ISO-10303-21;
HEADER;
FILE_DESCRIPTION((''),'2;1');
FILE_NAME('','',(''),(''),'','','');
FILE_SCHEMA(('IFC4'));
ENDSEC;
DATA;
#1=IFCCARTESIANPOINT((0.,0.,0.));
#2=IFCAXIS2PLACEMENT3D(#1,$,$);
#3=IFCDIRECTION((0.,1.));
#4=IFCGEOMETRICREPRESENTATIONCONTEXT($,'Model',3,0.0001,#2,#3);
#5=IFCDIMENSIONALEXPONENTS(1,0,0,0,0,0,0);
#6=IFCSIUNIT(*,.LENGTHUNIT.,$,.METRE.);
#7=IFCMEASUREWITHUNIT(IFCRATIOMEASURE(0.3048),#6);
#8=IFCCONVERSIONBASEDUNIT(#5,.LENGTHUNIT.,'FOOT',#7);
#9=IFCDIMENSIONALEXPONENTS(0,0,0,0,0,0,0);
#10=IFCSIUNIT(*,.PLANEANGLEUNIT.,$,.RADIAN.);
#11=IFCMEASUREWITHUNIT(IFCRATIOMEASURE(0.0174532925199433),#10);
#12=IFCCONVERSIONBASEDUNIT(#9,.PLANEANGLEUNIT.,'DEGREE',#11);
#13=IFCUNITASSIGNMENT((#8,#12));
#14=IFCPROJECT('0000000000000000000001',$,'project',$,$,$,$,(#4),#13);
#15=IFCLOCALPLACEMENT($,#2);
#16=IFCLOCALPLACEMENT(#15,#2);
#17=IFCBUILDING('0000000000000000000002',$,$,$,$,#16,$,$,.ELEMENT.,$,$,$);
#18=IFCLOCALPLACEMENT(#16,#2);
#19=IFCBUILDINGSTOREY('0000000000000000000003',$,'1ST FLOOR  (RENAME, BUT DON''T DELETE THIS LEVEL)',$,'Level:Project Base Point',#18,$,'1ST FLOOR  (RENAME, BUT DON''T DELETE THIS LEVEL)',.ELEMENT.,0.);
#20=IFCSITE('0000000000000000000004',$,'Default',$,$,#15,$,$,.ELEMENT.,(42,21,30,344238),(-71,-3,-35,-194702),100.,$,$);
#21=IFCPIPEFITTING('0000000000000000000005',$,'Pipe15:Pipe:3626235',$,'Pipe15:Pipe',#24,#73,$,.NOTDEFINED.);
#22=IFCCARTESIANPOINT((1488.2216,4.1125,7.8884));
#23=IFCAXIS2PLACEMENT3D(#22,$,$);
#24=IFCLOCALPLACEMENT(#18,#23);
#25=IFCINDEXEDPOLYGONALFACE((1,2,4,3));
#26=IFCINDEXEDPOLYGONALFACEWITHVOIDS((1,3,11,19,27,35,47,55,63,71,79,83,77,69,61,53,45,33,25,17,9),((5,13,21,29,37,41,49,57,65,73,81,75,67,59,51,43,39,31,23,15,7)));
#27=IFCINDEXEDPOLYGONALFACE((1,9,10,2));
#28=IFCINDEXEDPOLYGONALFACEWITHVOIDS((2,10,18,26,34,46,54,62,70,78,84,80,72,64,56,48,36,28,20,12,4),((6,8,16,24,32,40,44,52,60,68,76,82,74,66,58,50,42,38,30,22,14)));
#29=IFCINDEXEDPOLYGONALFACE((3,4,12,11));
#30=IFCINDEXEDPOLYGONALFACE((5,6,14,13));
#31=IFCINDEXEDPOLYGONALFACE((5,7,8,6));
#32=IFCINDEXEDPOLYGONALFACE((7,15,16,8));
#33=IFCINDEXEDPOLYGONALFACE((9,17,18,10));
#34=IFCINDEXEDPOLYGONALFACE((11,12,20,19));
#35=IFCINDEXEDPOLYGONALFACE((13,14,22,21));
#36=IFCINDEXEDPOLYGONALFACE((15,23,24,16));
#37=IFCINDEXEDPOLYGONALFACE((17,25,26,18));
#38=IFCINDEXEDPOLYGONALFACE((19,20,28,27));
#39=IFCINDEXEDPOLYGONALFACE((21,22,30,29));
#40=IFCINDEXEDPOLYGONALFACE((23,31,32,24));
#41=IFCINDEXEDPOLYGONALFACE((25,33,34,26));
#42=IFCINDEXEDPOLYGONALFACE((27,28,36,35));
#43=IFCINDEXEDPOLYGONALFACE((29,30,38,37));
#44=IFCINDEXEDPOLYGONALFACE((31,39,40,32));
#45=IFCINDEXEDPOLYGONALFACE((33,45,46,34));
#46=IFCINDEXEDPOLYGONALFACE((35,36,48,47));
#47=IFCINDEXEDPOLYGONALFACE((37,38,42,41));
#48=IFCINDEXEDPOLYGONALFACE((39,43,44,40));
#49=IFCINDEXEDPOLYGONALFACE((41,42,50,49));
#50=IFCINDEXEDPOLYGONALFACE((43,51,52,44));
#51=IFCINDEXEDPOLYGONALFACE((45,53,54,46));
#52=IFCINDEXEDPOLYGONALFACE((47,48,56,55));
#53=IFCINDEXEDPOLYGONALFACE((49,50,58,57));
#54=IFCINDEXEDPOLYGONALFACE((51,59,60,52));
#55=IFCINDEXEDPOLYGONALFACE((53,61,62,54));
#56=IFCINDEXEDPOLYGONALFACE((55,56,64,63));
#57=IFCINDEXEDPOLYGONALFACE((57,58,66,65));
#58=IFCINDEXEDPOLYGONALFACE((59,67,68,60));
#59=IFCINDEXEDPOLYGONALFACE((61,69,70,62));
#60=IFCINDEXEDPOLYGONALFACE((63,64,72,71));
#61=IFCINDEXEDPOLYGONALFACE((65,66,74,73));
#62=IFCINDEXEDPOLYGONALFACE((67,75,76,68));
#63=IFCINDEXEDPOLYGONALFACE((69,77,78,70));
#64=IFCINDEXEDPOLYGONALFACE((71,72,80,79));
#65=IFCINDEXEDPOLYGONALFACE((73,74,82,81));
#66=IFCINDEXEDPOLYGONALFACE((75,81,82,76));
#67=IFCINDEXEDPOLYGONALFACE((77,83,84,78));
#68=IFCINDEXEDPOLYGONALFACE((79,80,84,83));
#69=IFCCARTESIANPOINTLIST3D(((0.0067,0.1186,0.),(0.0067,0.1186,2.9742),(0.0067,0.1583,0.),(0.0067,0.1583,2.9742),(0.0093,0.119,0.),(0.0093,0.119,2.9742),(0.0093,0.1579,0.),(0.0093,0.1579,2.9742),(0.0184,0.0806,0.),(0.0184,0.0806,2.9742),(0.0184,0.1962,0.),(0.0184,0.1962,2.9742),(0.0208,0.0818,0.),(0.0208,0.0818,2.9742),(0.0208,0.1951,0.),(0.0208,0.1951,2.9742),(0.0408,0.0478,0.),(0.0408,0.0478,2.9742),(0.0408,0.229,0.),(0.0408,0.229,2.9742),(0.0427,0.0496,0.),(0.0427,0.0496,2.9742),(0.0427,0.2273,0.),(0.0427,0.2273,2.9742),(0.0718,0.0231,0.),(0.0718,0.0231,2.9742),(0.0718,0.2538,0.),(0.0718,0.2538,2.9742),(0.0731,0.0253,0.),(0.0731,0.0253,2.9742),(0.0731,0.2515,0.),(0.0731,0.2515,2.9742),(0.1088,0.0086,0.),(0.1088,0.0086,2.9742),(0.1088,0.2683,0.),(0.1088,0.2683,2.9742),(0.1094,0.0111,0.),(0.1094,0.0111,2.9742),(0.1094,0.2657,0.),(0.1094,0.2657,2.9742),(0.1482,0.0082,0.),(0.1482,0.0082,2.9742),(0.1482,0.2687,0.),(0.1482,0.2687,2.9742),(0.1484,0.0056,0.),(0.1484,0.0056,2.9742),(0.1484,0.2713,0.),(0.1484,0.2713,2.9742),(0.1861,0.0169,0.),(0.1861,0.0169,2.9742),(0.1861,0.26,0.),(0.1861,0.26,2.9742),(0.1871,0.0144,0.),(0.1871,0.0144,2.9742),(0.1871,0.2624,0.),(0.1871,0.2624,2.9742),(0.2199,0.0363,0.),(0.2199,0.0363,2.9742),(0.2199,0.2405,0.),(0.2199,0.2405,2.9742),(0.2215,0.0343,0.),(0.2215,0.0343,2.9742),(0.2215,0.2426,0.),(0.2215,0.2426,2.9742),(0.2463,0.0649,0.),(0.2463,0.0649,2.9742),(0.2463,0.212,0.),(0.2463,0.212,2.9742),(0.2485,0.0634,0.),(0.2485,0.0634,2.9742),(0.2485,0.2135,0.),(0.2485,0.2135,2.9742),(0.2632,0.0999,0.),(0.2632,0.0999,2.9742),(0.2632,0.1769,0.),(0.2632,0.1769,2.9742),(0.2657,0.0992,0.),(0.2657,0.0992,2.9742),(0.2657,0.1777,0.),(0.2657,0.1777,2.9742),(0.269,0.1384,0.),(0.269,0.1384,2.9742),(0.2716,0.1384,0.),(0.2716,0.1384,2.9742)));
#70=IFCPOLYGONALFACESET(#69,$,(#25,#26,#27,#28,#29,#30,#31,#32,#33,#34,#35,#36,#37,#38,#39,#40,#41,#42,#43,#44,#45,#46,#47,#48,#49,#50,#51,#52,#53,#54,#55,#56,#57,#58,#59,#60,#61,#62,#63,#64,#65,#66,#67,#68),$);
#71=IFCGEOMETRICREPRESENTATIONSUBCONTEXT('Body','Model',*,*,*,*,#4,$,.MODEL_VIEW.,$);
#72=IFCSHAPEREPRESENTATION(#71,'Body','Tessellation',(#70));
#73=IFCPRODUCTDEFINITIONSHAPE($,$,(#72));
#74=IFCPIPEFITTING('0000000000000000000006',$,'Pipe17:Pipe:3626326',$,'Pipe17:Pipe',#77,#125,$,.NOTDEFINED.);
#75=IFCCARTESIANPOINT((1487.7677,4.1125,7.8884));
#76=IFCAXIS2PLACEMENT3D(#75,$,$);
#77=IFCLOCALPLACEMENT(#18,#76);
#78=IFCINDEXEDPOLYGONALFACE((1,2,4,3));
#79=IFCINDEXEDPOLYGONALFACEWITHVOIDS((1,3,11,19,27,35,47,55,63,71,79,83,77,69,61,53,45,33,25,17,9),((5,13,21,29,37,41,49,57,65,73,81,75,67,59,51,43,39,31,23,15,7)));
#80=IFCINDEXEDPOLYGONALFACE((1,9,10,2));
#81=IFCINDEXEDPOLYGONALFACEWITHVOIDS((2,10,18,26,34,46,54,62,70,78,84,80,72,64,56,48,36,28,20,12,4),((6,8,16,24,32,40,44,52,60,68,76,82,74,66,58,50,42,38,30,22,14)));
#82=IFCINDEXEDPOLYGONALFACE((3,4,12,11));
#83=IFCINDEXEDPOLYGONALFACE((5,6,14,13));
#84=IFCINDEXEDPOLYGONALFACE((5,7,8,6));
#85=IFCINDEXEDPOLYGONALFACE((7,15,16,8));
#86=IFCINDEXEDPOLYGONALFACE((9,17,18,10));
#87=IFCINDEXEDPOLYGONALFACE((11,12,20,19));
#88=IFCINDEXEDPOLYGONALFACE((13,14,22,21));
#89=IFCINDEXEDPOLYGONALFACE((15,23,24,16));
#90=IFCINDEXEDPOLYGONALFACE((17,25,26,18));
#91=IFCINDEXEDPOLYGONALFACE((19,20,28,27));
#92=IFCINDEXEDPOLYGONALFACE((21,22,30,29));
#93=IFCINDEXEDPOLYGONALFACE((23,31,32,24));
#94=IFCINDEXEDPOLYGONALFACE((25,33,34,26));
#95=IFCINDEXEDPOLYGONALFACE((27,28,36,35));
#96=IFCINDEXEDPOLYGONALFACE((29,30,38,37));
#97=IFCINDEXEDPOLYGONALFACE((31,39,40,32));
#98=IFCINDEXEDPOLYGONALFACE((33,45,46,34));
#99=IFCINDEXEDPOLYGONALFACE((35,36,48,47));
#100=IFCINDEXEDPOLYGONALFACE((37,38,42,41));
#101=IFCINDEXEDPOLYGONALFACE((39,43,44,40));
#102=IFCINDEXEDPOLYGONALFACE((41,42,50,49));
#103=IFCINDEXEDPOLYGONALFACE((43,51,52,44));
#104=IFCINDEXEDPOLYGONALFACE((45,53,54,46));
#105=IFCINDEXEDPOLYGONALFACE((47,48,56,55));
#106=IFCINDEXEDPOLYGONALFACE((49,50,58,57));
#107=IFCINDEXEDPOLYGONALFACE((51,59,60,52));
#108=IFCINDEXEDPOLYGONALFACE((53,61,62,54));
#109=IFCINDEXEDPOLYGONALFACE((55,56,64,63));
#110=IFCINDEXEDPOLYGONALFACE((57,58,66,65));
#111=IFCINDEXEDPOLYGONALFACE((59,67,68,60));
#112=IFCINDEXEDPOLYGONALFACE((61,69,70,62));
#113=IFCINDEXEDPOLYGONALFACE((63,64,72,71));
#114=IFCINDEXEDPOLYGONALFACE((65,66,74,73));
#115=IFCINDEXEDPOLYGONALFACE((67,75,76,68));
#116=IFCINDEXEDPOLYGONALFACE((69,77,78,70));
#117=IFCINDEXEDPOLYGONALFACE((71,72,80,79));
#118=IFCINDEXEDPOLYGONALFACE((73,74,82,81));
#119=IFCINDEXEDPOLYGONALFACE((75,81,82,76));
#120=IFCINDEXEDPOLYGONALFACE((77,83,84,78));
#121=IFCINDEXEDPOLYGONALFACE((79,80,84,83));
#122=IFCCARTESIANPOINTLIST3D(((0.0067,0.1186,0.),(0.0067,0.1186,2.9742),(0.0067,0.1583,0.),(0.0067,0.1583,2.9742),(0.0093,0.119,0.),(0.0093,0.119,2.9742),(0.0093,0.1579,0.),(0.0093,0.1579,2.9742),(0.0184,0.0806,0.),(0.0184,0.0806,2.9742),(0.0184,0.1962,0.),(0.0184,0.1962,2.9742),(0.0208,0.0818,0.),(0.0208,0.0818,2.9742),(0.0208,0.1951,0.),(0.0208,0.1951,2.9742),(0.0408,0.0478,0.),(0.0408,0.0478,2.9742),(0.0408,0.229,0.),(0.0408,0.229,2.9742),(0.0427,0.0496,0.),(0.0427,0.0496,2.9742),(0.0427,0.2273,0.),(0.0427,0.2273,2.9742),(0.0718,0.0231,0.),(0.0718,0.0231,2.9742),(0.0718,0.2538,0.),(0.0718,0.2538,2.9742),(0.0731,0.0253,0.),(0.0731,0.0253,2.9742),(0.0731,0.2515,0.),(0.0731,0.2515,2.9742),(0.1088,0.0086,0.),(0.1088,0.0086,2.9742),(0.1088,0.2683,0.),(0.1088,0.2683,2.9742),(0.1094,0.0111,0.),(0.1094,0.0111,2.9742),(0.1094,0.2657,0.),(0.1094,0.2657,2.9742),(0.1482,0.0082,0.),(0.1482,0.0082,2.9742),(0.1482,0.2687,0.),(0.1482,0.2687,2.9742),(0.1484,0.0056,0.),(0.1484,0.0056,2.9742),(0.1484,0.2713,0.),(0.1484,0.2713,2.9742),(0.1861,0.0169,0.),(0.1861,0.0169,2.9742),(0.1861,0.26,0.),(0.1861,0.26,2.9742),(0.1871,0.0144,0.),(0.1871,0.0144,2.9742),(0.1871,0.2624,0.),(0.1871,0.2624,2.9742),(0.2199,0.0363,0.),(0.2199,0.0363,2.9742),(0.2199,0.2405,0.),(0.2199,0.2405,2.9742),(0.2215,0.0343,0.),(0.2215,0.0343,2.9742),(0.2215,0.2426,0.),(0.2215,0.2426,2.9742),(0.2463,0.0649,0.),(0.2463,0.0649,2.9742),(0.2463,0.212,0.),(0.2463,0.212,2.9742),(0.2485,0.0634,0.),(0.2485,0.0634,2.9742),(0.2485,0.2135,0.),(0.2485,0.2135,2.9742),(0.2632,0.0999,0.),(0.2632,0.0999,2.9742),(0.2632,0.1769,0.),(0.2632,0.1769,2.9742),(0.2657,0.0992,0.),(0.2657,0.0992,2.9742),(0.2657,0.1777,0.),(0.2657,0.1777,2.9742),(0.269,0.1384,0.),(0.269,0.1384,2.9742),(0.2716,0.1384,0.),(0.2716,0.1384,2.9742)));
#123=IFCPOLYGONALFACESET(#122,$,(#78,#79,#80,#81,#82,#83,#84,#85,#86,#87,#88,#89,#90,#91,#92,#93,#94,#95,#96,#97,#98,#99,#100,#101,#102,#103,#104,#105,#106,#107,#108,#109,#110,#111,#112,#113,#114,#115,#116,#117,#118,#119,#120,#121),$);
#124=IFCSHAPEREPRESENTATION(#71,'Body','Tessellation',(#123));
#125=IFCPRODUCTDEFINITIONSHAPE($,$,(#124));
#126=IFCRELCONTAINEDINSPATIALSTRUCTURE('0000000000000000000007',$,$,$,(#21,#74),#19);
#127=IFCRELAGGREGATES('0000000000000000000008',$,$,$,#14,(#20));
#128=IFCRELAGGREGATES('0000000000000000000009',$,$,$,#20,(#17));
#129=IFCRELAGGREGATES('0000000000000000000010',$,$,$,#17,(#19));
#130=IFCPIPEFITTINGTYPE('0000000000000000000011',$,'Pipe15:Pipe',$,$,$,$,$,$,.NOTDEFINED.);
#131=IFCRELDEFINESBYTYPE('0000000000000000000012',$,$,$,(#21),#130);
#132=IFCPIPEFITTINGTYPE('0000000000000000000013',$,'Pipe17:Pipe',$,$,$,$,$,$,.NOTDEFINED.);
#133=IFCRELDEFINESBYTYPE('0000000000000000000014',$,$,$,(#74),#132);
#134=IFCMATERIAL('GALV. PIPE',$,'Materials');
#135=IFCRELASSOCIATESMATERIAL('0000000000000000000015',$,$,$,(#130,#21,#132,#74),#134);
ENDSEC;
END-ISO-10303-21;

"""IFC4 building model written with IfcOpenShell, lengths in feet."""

from ifc_helpers import new_model, entity, si_unit, converted_unit, direction, frame, frame_2d, origin, place, context, subcontext, project, spatial, hollow_circle, extrude, source, transform, mapped, material, type_object, type_shapes, element, save


model = new_model("IFC4")

# Units and contexts
model_context = context("Model", 3, precision=0.0001, world=origin(), true_north=direction((0.0, 1.0)))
body_context = subcontext(model_context, "Body", "Model", "MODEL_VIEW")
ifc_project = project(units=[converted_unit("LENGTHUNIT", "FOOT", entity("IfcRatioMeasure", 0.3048), si_unit("LENGTHUNIT", "METRE"), dimensions=[1, 0, 0, 0, 0, 0, 0]), converted_unit("PLANEANGLEUNIT", "DEGREE", entity("IfcRatioMeasure", 0.0174532925199433), si_unit("PLANEANGLEUNIT", "RADIAN"), dimensions=[0, 0, 0, 0, 0, 0, 0])], contexts=[model_context])

# Site, building, storey
site_placement = place(None, origin())
site = spatial("IfcSite", under=ifc_project, at=site_placement, Name="Default", CompositionType="ELEMENT", RefLatitude=(42, 21, 30, 344238), RefLongitude=(-71, -3, -35, -194702), RefElevation=100.0)
building_placement = place(site_placement, origin())
building = spatial("IfcBuilding", under=site, at=building_placement, CompositionType="ELEMENT")
storey_placement = place(building_placement, origin())
storey = spatial("IfcBuildingStorey", under=building, at=storey_placement, Name="1ST FLOOR  (RENAME, BUT DON'T DELETE THIS LEVEL)", ObjectType="Level:Project Base Point", LongName="1ST FLOOR  (RENAME, BUT DON'T DELETE THIS LEVEL)", CompositionType="ELEMENT", Elevation=0.0)

# Shared definitions
ifc_material_1 = material(Name="GALV. PIPE", Category="Materials")

# Pipe fitting
pipe_fitting_type_1 = type_object("IfcPipeFittingType", Name="Pipe15:Pipe", PredefinedType="NOTDEFINED", material=ifc_material_1)
shared_shape_1 = source(origin(), body_context, "Body", "SweptSolid", [
    extrude(hollow_circle(Radius=0.1332, WallThickness=0.0026, at=frame_2d((0.0, 0.0), x_axis=(1.0, 0.0))), frame((0.1384, 0.1384, 0.0)), (0.0, 0.0, 1.0), 2.9742),
])
type_shapes(pipe_fitting_type_1, [shared_shape_1])
pipe_fitting_1_placement = place(storey_placement, frame((1488.2216, 4.1125, 7.8884)))
element("IfcPipeFitting", 1, at=pipe_fitting_1_placement, inside=storey, type_object=pipe_fitting_type_1, material=ifc_material_1, Name="Pipe15:Pipe:3626235", ObjectType="Pipe15:Pipe", PredefinedType="NOTDEFINED", context=body_context, shape_type="MappedRepresentation", body=[
    mapped(shared_shape_1, transform((0.0, 0.0, 0.0), scale=1.0)),
])

# Pipe fitting
pipe_fitting_type_2 = type_object("IfcPipeFittingType", Name="Pipe17:Pipe", PredefinedType="NOTDEFINED", material=ifc_material_1)
shared_shape_2 = source(origin(), body_context, "Body", "SweptSolid", [
    extrude(hollow_circle(Radius=0.1332, WallThickness=0.0026, at=frame_2d((0.0, 0.0), x_axis=(1.0, 0.0))), frame((0.1384, 0.1384, 0.0)), (0.0, 0.0, 1.0), 2.9742),
])
type_shapes(pipe_fitting_type_2, [shared_shape_2])
pipe_fitting_2_placement = place(storey_placement, frame((1487.7677, 4.1125, 7.8884)))
element("IfcPipeFitting", 2, at=pipe_fitting_2_placement, inside=storey, type_object=pipe_fitting_type_2, material=ifc_material_1, Name="Pipe17:Pipe:3626326", ObjectType="Pipe17:Pipe", PredefinedType="NOTDEFINED", context=body_context, shape_type="MappedRepresentation", body=[
    mapped(shared_shape_2, transform((0.0, 0.0, 0.0), scale=1.0)),
])

save(model, "model.ifc")
